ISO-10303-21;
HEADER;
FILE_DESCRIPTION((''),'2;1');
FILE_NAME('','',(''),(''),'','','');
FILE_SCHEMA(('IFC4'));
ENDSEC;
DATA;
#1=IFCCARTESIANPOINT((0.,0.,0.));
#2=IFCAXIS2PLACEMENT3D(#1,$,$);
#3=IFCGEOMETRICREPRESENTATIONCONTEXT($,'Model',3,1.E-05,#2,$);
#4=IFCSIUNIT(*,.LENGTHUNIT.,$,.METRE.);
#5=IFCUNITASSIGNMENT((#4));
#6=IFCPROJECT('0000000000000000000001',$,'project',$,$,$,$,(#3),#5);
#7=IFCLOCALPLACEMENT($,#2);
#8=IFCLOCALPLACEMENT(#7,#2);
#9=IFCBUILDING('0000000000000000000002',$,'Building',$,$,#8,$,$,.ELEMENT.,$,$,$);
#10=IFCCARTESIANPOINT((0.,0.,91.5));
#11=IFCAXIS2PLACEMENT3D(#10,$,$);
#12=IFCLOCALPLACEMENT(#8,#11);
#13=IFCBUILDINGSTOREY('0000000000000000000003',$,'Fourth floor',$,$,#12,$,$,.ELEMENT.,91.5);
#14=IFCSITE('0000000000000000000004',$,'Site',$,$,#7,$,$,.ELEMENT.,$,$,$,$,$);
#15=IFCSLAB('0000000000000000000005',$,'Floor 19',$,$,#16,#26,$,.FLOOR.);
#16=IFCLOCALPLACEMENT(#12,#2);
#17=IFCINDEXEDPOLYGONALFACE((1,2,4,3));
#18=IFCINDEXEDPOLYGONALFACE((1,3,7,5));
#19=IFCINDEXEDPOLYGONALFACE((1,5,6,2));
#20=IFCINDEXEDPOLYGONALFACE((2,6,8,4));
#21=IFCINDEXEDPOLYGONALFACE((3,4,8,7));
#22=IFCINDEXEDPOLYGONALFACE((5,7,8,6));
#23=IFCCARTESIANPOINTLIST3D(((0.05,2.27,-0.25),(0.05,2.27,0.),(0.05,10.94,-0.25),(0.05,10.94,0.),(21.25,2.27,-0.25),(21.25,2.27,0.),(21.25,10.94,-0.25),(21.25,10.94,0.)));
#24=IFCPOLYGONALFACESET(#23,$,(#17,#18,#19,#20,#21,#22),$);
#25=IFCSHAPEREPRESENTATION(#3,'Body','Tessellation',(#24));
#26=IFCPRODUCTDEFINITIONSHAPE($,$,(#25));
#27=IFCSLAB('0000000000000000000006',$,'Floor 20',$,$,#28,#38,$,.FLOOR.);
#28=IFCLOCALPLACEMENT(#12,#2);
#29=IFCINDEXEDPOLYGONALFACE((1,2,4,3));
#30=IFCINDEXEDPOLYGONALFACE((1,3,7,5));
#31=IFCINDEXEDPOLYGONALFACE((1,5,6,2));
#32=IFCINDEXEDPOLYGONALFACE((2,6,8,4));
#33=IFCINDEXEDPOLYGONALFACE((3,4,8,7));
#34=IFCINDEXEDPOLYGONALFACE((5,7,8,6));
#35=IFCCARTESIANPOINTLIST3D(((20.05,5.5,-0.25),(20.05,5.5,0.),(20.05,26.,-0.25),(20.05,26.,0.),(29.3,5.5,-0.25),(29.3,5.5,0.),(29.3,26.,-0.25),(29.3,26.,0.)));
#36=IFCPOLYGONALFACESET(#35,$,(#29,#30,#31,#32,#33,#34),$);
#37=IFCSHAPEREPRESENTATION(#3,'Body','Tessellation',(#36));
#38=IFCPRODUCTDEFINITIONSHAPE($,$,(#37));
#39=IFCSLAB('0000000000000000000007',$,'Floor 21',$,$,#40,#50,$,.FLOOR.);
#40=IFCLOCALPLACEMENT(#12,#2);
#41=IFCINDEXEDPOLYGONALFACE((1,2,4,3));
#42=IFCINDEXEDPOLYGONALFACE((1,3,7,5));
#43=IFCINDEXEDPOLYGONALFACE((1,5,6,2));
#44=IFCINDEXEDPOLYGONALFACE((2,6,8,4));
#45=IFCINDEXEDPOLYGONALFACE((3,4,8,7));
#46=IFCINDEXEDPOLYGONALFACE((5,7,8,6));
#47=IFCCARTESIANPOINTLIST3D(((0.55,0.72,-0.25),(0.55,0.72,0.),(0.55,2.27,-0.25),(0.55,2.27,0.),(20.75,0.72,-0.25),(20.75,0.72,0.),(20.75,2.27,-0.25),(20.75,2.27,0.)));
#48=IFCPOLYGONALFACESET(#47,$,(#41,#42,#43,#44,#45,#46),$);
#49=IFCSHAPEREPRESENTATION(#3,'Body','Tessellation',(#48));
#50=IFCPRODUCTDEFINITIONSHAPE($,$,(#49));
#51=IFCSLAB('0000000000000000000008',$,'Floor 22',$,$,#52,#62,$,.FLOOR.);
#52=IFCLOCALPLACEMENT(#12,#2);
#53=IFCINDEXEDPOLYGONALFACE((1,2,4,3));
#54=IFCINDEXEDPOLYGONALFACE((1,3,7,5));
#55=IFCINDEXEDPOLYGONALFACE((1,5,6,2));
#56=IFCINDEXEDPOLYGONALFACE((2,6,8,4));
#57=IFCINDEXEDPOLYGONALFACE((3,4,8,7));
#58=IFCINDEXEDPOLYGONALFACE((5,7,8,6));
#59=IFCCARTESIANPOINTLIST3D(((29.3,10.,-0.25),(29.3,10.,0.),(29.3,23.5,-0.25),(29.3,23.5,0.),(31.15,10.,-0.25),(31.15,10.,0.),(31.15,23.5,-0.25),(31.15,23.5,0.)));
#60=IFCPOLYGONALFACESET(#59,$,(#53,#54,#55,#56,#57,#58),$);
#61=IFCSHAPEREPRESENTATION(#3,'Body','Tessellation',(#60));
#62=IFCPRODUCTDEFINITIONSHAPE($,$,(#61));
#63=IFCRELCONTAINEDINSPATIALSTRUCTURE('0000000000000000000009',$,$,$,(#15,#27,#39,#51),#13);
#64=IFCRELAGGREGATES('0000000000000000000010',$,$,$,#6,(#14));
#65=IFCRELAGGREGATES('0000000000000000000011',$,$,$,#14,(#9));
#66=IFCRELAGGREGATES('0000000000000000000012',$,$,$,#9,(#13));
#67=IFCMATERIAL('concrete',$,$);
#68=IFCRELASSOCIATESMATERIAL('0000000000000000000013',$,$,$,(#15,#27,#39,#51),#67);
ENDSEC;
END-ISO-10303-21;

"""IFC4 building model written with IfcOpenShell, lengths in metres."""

from ifc_helpers import new_model, si_unit, frame, origin, place, context, project, spatial, polyline, outline, extrude, material, element, save


model = new_model("IFC4")

# Units and contexts
model_context = context("Model", 3, precision=1e-05, world=origin())
ifc_project = project(units=[si_unit("LENGTHUNIT", "METRE")], contexts=[model_context])

# Site, building, storey
site_placement = place(None, origin())
site = spatial("IfcSite", under=ifc_project, at=site_placement, Name="Site", CompositionType="ELEMENT")
building_placement = place(site_placement, origin())
building = spatial("IfcBuilding", under=site, at=building_placement, Name="Building", CompositionType="ELEMENT")
storey_placement = place(building_placement, frame((0.0, 0.0, 91.5)))
storey = spatial("IfcBuildingStorey", under=building, at=storey_placement, Name="Fourth floor", CompositionType="ELEMENT", Elevation=91.5)

# Slabs
ifc_material = material(Name="concrete")
slab_1_placement = place(storey_placement, frame((0.0, 0.0, -0.25), z_axis=(0.0, 0.0, 1.0), x_axis=(1.0, 0.0, 0.0)))
element("IfcSlab", 1, at=slab_1_placement, inside=storey, material=ifc_material, Name="Floor 19", PredefinedType="FLOOR", context=model_context, shape_type="SweptSolid", body=[
    extrude(outline(polyline([(0.05, 2.27), (21.25, 2.27), (21.25, 10.94), (0.05, 10.94), (0.05, 2.27)])), origin(), (0.0, 0.0, 1.0), 0.25),
])
slab_2_placement = place(storey_placement, frame((0.0, 0.0, -0.25), z_axis=(0.0, 0.0, 1.0), x_axis=(1.0, 0.0, 0.0)))
element("IfcSlab", 2, at=slab_2_placement, inside=storey, material=ifc_material, Name="Floor 20", PredefinedType="FLOOR", context=model_context, shape_type="SweptSolid", body=[
    extrude(outline(polyline([(20.05, 5.5), (29.3, 5.5), (29.3, 26.0), (20.05, 26.0), (20.05, 5.5)])), origin(), (0.0, 0.0, 1.0), 0.25),
])
slab_3_placement = place(storey_placement, frame((0.0, 0.0, -0.25), z_axis=(0.0, 0.0, 1.0), x_axis=(1.0, 0.0, 0.0)))
element("IfcSlab", 3, at=slab_3_placement, inside=storey, material=ifc_material, Name="Floor 21", PredefinedType="FLOOR", context=model_context, shape_type="SweptSolid", body=[
    extrude(outline(polyline([(0.55, 0.72), (20.75, 0.72), (20.75, 2.27), (0.55, 2.27), (0.55, 0.72)])), origin(), (0.0, 0.0, 1.0), 0.25),
])
slab_4_placement = place(storey_placement, frame((0.0, 0.0, -0.25), z_axis=(0.0, 0.0, 1.0), x_axis=(1.0, 0.0, 0.0)))
element("IfcSlab", 4, at=slab_4_placement, inside=storey, material=ifc_material, Name="Floor 22", PredefinedType="FLOOR", context=model_context, shape_type="SweptSolid", body=[
    extrude(outline(polyline([(29.3, 10.0), (31.15, 10.0), (31.15, 23.5), (29.3, 23.5), (29.3, 10.0)])), origin(), (0.0, 0.0, 1.0), 0.25),
])

save(model, "model.ifc")
